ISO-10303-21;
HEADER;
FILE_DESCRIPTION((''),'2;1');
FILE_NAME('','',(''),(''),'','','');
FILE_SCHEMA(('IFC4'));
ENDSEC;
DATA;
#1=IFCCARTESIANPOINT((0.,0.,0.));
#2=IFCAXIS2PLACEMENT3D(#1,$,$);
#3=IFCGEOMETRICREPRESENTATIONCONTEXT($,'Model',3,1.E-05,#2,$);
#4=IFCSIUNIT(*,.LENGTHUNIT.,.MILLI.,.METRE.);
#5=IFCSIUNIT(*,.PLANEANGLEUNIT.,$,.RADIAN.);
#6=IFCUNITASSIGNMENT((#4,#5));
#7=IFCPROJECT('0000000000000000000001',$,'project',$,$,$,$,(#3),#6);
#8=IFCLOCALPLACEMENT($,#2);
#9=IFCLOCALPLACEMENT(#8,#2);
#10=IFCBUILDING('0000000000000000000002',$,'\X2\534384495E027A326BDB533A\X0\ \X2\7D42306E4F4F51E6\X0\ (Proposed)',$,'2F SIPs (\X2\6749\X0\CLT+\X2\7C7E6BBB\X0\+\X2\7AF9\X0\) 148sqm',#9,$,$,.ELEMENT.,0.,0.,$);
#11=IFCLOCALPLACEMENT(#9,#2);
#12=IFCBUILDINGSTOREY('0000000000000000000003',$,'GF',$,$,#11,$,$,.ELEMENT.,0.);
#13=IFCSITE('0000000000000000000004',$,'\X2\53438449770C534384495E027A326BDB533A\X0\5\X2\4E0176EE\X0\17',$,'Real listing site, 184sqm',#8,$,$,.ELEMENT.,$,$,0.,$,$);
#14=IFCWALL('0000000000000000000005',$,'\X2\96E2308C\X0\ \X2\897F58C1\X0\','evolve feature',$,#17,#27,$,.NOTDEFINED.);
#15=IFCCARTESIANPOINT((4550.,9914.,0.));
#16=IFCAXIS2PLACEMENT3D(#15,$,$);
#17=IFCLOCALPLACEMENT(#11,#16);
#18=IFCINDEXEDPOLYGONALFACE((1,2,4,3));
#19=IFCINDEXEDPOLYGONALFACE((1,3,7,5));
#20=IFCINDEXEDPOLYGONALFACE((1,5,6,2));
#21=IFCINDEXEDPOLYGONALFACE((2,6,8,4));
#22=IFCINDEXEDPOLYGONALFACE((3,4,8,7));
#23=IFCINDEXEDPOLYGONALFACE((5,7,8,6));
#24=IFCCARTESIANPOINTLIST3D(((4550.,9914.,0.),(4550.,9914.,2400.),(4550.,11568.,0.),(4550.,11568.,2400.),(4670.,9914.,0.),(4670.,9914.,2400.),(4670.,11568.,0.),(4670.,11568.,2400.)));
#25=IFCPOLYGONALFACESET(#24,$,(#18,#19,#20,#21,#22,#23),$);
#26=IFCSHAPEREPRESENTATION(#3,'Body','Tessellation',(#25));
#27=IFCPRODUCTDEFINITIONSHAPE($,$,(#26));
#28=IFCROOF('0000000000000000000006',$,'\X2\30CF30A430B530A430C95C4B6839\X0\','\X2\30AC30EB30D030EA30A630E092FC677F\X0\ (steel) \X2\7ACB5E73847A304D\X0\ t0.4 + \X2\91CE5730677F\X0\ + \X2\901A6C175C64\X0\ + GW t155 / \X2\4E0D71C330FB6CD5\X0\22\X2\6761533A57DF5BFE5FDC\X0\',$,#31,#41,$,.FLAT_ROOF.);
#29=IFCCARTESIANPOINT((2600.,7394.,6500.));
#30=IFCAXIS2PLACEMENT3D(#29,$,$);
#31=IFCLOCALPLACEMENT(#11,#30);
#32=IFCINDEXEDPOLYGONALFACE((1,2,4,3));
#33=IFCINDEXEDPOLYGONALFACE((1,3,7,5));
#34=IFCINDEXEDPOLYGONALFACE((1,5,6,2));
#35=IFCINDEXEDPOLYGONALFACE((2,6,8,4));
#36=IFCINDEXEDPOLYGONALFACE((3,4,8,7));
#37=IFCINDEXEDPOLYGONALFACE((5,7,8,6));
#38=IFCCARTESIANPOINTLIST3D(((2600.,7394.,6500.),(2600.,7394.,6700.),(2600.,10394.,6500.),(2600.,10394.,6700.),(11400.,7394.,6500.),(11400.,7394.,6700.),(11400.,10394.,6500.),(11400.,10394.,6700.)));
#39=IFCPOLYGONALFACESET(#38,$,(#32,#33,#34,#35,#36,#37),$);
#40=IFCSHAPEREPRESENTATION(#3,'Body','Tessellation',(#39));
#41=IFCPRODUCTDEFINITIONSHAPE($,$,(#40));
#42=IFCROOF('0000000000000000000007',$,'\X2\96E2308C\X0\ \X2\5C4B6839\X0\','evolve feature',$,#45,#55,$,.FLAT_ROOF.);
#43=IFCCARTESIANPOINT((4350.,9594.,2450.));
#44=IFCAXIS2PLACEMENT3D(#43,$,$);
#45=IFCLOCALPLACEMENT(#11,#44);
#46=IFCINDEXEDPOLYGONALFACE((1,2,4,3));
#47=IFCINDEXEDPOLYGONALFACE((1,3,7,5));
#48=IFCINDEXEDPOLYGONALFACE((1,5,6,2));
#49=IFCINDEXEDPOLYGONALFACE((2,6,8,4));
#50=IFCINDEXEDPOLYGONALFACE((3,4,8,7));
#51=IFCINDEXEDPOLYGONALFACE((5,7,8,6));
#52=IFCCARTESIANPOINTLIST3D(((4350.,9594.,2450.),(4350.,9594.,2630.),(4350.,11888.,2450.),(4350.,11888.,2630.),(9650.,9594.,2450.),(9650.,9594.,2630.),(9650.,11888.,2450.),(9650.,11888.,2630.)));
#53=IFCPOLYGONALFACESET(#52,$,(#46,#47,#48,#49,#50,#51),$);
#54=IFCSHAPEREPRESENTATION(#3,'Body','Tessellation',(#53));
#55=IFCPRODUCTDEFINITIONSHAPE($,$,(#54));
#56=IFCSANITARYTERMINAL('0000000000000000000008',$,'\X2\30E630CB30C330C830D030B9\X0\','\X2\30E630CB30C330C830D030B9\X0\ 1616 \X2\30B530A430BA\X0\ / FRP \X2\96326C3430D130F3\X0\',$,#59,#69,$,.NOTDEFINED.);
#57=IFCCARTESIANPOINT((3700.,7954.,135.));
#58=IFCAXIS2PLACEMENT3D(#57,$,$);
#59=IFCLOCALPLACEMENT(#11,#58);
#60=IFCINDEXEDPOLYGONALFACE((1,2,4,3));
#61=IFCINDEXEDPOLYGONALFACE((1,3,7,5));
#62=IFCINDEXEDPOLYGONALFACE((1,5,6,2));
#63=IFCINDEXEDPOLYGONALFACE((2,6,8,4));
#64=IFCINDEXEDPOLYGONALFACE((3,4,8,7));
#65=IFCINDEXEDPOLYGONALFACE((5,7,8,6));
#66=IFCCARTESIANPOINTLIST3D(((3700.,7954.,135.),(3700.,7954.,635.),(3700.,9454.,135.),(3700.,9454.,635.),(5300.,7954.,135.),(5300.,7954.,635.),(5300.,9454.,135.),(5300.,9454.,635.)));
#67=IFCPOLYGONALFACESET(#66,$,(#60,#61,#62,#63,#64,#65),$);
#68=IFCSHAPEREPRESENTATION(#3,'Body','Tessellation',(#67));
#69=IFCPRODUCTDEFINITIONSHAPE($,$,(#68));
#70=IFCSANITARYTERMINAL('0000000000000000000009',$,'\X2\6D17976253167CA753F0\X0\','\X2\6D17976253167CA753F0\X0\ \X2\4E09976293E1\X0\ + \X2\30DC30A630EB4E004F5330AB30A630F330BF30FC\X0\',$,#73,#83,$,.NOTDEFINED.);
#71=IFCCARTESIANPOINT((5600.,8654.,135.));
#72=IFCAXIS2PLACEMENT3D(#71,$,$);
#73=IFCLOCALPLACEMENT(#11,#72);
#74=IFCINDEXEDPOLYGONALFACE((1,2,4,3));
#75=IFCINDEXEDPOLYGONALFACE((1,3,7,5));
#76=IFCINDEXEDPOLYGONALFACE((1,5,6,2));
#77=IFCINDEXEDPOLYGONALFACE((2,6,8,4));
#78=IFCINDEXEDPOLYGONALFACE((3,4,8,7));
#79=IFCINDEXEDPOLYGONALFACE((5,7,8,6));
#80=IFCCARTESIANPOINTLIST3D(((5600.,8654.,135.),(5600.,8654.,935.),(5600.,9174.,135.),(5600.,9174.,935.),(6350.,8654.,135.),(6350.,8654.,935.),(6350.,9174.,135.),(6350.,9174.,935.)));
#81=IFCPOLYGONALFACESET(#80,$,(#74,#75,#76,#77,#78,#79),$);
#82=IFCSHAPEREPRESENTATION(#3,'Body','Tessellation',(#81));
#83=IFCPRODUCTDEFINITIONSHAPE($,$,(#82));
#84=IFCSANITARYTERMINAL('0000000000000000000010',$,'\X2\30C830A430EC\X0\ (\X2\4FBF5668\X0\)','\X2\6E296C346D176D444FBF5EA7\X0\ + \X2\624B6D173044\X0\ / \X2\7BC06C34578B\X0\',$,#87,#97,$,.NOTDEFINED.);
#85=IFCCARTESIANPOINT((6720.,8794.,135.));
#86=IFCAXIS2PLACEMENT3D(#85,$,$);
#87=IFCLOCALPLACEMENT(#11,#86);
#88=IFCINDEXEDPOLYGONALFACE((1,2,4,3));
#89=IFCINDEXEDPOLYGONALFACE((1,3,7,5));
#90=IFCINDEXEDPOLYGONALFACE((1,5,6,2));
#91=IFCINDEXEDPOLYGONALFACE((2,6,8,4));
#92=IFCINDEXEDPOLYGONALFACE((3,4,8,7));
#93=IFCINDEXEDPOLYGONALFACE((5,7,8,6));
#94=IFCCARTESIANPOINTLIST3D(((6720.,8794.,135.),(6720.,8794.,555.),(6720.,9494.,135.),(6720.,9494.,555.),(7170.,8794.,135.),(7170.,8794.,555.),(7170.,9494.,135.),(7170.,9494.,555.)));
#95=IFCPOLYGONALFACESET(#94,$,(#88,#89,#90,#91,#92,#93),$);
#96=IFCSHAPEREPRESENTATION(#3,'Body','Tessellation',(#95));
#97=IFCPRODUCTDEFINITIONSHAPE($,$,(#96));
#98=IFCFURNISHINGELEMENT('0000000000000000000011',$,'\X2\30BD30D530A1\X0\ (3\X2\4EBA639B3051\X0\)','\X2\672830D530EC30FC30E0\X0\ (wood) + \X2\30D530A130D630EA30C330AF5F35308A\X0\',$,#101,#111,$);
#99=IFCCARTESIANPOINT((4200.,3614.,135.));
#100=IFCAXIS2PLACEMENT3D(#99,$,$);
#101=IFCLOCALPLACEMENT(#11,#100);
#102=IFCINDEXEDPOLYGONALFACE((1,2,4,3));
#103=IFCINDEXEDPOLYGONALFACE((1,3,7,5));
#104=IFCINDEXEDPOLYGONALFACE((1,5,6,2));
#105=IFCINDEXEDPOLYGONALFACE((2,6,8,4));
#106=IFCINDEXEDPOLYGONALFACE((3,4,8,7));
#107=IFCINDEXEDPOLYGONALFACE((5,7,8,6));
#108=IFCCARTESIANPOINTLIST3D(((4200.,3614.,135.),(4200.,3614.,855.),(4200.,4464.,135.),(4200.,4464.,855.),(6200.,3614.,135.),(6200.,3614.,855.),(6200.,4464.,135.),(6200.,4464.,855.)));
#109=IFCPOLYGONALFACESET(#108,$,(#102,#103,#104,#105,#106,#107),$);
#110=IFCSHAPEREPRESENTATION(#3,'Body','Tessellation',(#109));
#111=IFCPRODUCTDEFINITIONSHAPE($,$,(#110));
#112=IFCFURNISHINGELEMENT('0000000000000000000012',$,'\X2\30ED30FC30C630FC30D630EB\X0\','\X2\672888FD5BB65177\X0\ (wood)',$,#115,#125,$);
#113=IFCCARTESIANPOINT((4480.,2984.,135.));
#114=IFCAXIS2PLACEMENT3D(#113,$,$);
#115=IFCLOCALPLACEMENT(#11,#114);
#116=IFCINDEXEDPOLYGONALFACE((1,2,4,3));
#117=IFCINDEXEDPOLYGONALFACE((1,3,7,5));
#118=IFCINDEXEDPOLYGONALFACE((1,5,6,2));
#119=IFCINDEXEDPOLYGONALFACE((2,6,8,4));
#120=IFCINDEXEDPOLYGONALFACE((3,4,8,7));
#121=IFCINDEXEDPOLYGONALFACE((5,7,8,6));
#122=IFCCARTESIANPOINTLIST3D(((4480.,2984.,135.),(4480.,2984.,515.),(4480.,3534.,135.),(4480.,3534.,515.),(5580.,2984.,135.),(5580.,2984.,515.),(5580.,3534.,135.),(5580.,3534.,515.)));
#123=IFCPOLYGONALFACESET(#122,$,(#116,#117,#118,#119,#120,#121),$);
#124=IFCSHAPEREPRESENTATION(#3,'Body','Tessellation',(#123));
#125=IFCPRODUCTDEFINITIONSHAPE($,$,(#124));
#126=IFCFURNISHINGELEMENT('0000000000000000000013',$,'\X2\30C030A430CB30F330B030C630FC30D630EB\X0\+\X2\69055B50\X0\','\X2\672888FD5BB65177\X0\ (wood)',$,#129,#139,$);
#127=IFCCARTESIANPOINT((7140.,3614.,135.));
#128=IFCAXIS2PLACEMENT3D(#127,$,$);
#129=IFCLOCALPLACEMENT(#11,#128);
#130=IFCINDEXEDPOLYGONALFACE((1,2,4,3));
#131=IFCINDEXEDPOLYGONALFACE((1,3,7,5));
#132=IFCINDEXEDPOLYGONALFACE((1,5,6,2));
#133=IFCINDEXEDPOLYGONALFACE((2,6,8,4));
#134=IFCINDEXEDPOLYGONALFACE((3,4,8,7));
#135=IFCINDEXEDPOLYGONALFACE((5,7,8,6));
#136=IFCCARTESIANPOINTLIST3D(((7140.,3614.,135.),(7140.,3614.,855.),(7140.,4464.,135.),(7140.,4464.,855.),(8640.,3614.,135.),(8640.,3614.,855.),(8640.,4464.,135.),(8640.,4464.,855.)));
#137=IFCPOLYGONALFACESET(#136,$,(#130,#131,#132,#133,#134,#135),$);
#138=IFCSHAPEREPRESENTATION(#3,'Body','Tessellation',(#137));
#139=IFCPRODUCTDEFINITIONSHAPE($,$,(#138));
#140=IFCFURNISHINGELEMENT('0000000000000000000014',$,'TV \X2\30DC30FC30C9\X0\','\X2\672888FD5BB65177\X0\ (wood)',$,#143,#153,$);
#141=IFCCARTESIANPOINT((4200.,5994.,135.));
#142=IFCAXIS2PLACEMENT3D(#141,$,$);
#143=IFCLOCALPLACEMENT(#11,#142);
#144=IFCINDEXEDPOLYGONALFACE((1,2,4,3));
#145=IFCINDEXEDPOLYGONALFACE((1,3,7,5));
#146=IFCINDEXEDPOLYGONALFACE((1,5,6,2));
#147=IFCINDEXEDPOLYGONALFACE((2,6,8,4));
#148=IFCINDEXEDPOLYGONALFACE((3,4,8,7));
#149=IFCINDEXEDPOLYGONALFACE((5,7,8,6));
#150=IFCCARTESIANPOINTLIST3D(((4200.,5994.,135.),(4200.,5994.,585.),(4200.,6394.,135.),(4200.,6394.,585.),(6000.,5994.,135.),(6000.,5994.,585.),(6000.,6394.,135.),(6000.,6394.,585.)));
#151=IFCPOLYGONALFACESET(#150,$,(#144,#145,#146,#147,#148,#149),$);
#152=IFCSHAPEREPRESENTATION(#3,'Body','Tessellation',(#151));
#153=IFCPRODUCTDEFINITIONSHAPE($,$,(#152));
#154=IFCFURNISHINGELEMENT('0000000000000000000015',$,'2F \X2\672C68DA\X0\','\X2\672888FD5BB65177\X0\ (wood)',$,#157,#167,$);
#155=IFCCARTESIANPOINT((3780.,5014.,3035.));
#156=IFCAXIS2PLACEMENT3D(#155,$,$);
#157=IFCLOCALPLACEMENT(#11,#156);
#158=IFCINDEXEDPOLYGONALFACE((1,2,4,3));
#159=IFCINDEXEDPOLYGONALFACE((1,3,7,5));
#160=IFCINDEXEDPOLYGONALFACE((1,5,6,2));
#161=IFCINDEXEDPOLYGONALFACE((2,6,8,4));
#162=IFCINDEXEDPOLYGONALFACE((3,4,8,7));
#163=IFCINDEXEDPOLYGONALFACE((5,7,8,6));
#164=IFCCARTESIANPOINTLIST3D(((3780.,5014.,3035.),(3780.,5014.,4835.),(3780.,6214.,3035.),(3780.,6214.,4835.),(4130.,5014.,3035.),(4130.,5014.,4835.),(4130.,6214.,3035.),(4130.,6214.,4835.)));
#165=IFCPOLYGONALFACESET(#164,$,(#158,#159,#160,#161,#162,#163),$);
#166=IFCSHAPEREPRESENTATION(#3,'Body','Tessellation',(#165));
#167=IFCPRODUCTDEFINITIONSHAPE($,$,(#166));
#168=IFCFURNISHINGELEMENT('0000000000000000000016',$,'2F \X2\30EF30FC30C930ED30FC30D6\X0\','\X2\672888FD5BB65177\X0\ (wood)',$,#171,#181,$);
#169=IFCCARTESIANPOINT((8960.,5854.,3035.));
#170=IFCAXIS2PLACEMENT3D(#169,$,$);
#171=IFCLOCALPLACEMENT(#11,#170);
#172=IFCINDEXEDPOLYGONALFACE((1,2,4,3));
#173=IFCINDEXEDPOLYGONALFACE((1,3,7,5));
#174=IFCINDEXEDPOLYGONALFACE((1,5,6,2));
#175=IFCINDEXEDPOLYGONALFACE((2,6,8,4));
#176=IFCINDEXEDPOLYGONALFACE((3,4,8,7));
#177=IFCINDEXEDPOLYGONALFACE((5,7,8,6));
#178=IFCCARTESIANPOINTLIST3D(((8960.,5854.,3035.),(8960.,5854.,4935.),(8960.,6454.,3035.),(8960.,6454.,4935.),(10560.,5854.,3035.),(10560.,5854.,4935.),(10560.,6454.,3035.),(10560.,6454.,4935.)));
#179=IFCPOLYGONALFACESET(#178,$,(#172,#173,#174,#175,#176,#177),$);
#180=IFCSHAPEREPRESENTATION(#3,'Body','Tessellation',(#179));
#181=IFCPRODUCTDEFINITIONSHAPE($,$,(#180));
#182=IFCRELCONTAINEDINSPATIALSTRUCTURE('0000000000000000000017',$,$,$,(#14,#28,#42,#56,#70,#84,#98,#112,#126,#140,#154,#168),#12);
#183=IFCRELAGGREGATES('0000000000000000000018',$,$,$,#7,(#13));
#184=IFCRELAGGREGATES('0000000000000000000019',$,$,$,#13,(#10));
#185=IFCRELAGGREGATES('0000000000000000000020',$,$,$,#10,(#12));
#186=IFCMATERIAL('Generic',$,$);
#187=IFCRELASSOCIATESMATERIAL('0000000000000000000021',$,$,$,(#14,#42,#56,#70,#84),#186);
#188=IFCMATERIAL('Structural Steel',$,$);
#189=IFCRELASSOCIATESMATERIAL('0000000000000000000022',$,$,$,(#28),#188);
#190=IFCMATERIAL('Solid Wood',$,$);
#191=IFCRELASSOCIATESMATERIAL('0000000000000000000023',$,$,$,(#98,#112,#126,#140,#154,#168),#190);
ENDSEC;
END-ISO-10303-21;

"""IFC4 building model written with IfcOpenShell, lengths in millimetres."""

from ifc_helpers import new_model, si_unit, frame, frame_2d, origin, place, context, project, spatial, rectangle, extrude, material, element, save


model = new_model("IFC4")

# Units and contexts
model_context = context("Model", 3, precision=1e-05, world=origin())
ifc_project = project(units=[si_unit("LENGTHUNIT", "METRE", prefix="MILLI"), si_unit("PLANEANGLEUNIT", "RADIAN")], contexts=[model_context])

# Site, building, storey
site_placement = place(None, origin())
site = spatial("IfcSite", under=ifc_project, at=site_placement, Name="千葉県千葉市稲毛区5丁目17", ObjectType="Real listing site, 184sqm", CompositionType="ELEMENT", RefElevation=0.0)
building_placement = place(site_placement, origin())
building = spatial("IfcBuilding", under=site, at=building_placement, Name="千葉市稲毛区 終の住処 (Proposed)", ObjectType="2F SIPs (杉CLT+籾殻+竹) 148sqm", CompositionType="ELEMENT", ElevationOfRefHeight=0.0, ElevationOfTerrain=0.0)
storey_placement = place(building_placement, origin())
storey = spatial("IfcBuildingStorey", under=building, at=storey_placement, Name="GF", CompositionType="ELEMENT", Elevation=0.0)

# Shared definitions
ifc_material_1 = material(Name="Generic")

# Shared definitions
ifc_material_2 = material(Name="Solid Wood")

# Wall
wall_1_placement = place(storey_placement, frame((4550.0, 9914.0, 0.0)))
element("IfcWall", 1, at=wall_1_placement, inside=storey, material=ifc_material_1, Name="離れ 西壁", Description="evolve feature", PredefinedType="NOTDEFINED", context=model_context, shape_type="SweptSolid", body=[
    extrude(rectangle(XDim=120.0, YDim=1654.0, at=frame_2d((60.0, 827.0))), frame((4550.0, 9914.0, 0.0)), (0.0, 0.0, 1.0), 2400.0),
])

# Roofs
ifc_material_3 = material(Name="Structural Steel")
roof_1_placement = place(storey_placement, frame((2600.0, 7394.0, 6500.0)))
element("IfcRoof", 2, at=roof_1_placement, inside=storey, material=ifc_material_3, Name="ハイサイド屋根", Description="ガルバリウム鋼板 (steel) 立平葺き t0.4 + 野地板 + 通気層 + GW t155 / 不燃・法22条区域対応", PredefinedType="FLAT_ROOF", context=model_context, shape_type="SweptSolid", body=[
    extrude(rectangle(XDim=8800.0, YDim=3000.0, at=frame_2d((4400.0, 1500.0))), frame((2600.0, 7394.0, 6500.0)), (0.0, 0.0, 1.0), 200.0),
])
roof_2_placement = place(storey_placement, frame((4350.0, 9594.0, 2450.0)))
element("IfcRoof", 3, at=roof_2_placement, inside=storey, material=ifc_material_1, Name="離れ 屋根", Description="evolve feature", PredefinedType="FLAT_ROOF", context=model_context, shape_type="SweptSolid", body=[
    extrude(rectangle(XDim=5300.0, YDim=2294.0, at=frame_2d((2650.0, 1147.0))), frame((4350.0, 9594.0, 2450.0)), (0.0, 0.0, 1.0), 180.0),
])

# Sanitary terminals
sanitary_terminal_1_placement = place(storey_placement, frame((3700.0, 7954.0, 135.0)))
element("IfcSanitaryTerminal", 4, at=sanitary_terminal_1_placement, inside=storey, material=ifc_material_1, Name="ユニットバス", Description="ユニットバス 1616 サイズ / FRP 防水パン", PredefinedType="NOTDEFINED", context=model_context, shape_type="SweptSolid", body=[
    extrude(rectangle(XDim=1600.0, YDim=1500.0, at=frame_2d((800.0, 750.0))), frame((3700.0, 7954.0, 135.0)), (0.0, 0.0, 1.0), 500.0),
])
sanitary_terminal_2_placement = place(storey_placement, frame((5600.0, 8654.0, 135.0)))
element("IfcSanitaryTerminal", 5, at=sanitary_terminal_2_placement, inside=storey, material=ifc_material_1, Name="洗面化粧台", Description="洗面化粧台 三面鏡 + ボウル一体カウンター", PredefinedType="NOTDEFINED", context=model_context, shape_type="SweptSolid", body=[
    extrude(rectangle(XDim=750.0, YDim=520.0, at=frame_2d((375.0, 260.0))), frame((5600.0, 8654.0, 135.0)), (0.0, 0.0, 1.0), 800.0),
])
sanitary_terminal_3_placement = place(storey_placement, frame((6720.0, 8794.0, 135.0)))
element("IfcSanitaryTerminal", 6, at=sanitary_terminal_3_placement, inside=storey, material=ifc_material_1, Name="トイレ (便器)", Description="温水洗浄便座 + 手洗い / 節水型", PredefinedType="NOTDEFINED", context=model_context, shape_type="SweptSolid", body=[
    extrude(rectangle(XDim=450.0, YDim=700.0, at=frame_2d((225.0, 350.0))), frame((6720.0, 8794.0, 135.0)), (0.0, 0.0, 1.0), 420.0),
])

# Furnishing elements
furnishing_1_placement = place(storey_placement, frame((4200.0, 3614.0, 135.0)))
element("IfcFurnishingElement", 7, at=furnishing_1_placement, inside=storey, material=ifc_material_2, Name="ソファ (3人掛け)", Description="木フレーム (wood) + ファブリック張り", context=model_context, shape_type="SweptSolid", body=[
    extrude(rectangle(XDim=2000.0, YDim=850.0, at=frame_2d((1000.0, 425.0))), frame((4200.0, 3614.0, 135.0)), (0.0, 0.0, 1.0), 720.0),
])
furnishing_2_placement = place(storey_placement, frame((4480.0, 2984.0, 135.0)))
element("IfcFurnishingElement", 8, at=furnishing_2_placement, inside=storey, material=ifc_material_2, Name="ローテーブル", Description="木製家具 (wood)", context=model_context, shape_type="SweptSolid", body=[
    extrude(rectangle(XDim=1100.0, YDim=550.0, at=frame_2d((550.0, 275.0))), frame((4480.0, 2984.0, 135.0)), (0.0, 0.0, 1.0), 380.0),
])
furnishing_3_placement = place(storey_placement, frame((7140.0, 3614.0, 135.0)))
element("IfcFurnishingElement", 9, at=furnishing_3_placement, inside=storey, material=ifc_material_2, Name="ダイニングテーブル+椅子", Description="木製家具 (wood)", context=model_context, shape_type="SweptSolid", body=[
    extrude(rectangle(XDim=1500.0, YDim=850.0, at=frame_2d((750.0, 425.0))), frame((7140.0, 3614.0, 135.0)), (0.0, 0.0, 1.0), 720.0),
])
furnishing_4_placement = place(storey_placement, frame((4200.0, 5994.0, 135.0)))
element("IfcFurnishingElement", 10, at=furnishing_4_placement, inside=storey, material=ifc_material_2, Name="TV ボード", Description="木製家具 (wood)", context=model_context, shape_type="SweptSolid", body=[
    extrude(rectangle(XDim=1800.0, YDim=400.0, at=frame_2d((900.0, 200.0))), frame((4200.0, 5994.0, 135.0)), (0.0, 0.0, 1.0), 450.0),
])
furnishing_5_placement = place(storey_placement, frame((3780.0, 5014.0, 3035.0)))
element("IfcFurnishingElement", 11, at=furnishing_5_placement, inside=storey, material=ifc_material_2, Name="2F 本棚", Description="木製家具 (wood)", context=model_context, shape_type="SweptSolid", body=[
    extrude(rectangle(XDim=350.0, YDim=1200.0, at=frame_2d((175.0, 600.0))), frame((3780.0, 5014.0, 3035.0)), (0.0, 0.0, 1.0), 1800.0),
])
furnishing_6_placement = place(storey_placement, frame((8960.0, 5854.0, 3035.0)))
element("IfcFurnishingElement", 12, at=furnishing_6_placement, inside=storey, material=ifc_material_2, Name="2F ワードローブ", Description="木製家具 (wood)", context=model_context, shape_type="SweptSolid", body=[
    extrude(rectangle(XDim=1600.0, YDim=600.0, at=frame_2d((800.0, 300.0))), frame((8960.0, 5854.0, 3035.0)), (0.0, 0.0, 1.0), 1900.0),
])

save(model, "model.ifc")
